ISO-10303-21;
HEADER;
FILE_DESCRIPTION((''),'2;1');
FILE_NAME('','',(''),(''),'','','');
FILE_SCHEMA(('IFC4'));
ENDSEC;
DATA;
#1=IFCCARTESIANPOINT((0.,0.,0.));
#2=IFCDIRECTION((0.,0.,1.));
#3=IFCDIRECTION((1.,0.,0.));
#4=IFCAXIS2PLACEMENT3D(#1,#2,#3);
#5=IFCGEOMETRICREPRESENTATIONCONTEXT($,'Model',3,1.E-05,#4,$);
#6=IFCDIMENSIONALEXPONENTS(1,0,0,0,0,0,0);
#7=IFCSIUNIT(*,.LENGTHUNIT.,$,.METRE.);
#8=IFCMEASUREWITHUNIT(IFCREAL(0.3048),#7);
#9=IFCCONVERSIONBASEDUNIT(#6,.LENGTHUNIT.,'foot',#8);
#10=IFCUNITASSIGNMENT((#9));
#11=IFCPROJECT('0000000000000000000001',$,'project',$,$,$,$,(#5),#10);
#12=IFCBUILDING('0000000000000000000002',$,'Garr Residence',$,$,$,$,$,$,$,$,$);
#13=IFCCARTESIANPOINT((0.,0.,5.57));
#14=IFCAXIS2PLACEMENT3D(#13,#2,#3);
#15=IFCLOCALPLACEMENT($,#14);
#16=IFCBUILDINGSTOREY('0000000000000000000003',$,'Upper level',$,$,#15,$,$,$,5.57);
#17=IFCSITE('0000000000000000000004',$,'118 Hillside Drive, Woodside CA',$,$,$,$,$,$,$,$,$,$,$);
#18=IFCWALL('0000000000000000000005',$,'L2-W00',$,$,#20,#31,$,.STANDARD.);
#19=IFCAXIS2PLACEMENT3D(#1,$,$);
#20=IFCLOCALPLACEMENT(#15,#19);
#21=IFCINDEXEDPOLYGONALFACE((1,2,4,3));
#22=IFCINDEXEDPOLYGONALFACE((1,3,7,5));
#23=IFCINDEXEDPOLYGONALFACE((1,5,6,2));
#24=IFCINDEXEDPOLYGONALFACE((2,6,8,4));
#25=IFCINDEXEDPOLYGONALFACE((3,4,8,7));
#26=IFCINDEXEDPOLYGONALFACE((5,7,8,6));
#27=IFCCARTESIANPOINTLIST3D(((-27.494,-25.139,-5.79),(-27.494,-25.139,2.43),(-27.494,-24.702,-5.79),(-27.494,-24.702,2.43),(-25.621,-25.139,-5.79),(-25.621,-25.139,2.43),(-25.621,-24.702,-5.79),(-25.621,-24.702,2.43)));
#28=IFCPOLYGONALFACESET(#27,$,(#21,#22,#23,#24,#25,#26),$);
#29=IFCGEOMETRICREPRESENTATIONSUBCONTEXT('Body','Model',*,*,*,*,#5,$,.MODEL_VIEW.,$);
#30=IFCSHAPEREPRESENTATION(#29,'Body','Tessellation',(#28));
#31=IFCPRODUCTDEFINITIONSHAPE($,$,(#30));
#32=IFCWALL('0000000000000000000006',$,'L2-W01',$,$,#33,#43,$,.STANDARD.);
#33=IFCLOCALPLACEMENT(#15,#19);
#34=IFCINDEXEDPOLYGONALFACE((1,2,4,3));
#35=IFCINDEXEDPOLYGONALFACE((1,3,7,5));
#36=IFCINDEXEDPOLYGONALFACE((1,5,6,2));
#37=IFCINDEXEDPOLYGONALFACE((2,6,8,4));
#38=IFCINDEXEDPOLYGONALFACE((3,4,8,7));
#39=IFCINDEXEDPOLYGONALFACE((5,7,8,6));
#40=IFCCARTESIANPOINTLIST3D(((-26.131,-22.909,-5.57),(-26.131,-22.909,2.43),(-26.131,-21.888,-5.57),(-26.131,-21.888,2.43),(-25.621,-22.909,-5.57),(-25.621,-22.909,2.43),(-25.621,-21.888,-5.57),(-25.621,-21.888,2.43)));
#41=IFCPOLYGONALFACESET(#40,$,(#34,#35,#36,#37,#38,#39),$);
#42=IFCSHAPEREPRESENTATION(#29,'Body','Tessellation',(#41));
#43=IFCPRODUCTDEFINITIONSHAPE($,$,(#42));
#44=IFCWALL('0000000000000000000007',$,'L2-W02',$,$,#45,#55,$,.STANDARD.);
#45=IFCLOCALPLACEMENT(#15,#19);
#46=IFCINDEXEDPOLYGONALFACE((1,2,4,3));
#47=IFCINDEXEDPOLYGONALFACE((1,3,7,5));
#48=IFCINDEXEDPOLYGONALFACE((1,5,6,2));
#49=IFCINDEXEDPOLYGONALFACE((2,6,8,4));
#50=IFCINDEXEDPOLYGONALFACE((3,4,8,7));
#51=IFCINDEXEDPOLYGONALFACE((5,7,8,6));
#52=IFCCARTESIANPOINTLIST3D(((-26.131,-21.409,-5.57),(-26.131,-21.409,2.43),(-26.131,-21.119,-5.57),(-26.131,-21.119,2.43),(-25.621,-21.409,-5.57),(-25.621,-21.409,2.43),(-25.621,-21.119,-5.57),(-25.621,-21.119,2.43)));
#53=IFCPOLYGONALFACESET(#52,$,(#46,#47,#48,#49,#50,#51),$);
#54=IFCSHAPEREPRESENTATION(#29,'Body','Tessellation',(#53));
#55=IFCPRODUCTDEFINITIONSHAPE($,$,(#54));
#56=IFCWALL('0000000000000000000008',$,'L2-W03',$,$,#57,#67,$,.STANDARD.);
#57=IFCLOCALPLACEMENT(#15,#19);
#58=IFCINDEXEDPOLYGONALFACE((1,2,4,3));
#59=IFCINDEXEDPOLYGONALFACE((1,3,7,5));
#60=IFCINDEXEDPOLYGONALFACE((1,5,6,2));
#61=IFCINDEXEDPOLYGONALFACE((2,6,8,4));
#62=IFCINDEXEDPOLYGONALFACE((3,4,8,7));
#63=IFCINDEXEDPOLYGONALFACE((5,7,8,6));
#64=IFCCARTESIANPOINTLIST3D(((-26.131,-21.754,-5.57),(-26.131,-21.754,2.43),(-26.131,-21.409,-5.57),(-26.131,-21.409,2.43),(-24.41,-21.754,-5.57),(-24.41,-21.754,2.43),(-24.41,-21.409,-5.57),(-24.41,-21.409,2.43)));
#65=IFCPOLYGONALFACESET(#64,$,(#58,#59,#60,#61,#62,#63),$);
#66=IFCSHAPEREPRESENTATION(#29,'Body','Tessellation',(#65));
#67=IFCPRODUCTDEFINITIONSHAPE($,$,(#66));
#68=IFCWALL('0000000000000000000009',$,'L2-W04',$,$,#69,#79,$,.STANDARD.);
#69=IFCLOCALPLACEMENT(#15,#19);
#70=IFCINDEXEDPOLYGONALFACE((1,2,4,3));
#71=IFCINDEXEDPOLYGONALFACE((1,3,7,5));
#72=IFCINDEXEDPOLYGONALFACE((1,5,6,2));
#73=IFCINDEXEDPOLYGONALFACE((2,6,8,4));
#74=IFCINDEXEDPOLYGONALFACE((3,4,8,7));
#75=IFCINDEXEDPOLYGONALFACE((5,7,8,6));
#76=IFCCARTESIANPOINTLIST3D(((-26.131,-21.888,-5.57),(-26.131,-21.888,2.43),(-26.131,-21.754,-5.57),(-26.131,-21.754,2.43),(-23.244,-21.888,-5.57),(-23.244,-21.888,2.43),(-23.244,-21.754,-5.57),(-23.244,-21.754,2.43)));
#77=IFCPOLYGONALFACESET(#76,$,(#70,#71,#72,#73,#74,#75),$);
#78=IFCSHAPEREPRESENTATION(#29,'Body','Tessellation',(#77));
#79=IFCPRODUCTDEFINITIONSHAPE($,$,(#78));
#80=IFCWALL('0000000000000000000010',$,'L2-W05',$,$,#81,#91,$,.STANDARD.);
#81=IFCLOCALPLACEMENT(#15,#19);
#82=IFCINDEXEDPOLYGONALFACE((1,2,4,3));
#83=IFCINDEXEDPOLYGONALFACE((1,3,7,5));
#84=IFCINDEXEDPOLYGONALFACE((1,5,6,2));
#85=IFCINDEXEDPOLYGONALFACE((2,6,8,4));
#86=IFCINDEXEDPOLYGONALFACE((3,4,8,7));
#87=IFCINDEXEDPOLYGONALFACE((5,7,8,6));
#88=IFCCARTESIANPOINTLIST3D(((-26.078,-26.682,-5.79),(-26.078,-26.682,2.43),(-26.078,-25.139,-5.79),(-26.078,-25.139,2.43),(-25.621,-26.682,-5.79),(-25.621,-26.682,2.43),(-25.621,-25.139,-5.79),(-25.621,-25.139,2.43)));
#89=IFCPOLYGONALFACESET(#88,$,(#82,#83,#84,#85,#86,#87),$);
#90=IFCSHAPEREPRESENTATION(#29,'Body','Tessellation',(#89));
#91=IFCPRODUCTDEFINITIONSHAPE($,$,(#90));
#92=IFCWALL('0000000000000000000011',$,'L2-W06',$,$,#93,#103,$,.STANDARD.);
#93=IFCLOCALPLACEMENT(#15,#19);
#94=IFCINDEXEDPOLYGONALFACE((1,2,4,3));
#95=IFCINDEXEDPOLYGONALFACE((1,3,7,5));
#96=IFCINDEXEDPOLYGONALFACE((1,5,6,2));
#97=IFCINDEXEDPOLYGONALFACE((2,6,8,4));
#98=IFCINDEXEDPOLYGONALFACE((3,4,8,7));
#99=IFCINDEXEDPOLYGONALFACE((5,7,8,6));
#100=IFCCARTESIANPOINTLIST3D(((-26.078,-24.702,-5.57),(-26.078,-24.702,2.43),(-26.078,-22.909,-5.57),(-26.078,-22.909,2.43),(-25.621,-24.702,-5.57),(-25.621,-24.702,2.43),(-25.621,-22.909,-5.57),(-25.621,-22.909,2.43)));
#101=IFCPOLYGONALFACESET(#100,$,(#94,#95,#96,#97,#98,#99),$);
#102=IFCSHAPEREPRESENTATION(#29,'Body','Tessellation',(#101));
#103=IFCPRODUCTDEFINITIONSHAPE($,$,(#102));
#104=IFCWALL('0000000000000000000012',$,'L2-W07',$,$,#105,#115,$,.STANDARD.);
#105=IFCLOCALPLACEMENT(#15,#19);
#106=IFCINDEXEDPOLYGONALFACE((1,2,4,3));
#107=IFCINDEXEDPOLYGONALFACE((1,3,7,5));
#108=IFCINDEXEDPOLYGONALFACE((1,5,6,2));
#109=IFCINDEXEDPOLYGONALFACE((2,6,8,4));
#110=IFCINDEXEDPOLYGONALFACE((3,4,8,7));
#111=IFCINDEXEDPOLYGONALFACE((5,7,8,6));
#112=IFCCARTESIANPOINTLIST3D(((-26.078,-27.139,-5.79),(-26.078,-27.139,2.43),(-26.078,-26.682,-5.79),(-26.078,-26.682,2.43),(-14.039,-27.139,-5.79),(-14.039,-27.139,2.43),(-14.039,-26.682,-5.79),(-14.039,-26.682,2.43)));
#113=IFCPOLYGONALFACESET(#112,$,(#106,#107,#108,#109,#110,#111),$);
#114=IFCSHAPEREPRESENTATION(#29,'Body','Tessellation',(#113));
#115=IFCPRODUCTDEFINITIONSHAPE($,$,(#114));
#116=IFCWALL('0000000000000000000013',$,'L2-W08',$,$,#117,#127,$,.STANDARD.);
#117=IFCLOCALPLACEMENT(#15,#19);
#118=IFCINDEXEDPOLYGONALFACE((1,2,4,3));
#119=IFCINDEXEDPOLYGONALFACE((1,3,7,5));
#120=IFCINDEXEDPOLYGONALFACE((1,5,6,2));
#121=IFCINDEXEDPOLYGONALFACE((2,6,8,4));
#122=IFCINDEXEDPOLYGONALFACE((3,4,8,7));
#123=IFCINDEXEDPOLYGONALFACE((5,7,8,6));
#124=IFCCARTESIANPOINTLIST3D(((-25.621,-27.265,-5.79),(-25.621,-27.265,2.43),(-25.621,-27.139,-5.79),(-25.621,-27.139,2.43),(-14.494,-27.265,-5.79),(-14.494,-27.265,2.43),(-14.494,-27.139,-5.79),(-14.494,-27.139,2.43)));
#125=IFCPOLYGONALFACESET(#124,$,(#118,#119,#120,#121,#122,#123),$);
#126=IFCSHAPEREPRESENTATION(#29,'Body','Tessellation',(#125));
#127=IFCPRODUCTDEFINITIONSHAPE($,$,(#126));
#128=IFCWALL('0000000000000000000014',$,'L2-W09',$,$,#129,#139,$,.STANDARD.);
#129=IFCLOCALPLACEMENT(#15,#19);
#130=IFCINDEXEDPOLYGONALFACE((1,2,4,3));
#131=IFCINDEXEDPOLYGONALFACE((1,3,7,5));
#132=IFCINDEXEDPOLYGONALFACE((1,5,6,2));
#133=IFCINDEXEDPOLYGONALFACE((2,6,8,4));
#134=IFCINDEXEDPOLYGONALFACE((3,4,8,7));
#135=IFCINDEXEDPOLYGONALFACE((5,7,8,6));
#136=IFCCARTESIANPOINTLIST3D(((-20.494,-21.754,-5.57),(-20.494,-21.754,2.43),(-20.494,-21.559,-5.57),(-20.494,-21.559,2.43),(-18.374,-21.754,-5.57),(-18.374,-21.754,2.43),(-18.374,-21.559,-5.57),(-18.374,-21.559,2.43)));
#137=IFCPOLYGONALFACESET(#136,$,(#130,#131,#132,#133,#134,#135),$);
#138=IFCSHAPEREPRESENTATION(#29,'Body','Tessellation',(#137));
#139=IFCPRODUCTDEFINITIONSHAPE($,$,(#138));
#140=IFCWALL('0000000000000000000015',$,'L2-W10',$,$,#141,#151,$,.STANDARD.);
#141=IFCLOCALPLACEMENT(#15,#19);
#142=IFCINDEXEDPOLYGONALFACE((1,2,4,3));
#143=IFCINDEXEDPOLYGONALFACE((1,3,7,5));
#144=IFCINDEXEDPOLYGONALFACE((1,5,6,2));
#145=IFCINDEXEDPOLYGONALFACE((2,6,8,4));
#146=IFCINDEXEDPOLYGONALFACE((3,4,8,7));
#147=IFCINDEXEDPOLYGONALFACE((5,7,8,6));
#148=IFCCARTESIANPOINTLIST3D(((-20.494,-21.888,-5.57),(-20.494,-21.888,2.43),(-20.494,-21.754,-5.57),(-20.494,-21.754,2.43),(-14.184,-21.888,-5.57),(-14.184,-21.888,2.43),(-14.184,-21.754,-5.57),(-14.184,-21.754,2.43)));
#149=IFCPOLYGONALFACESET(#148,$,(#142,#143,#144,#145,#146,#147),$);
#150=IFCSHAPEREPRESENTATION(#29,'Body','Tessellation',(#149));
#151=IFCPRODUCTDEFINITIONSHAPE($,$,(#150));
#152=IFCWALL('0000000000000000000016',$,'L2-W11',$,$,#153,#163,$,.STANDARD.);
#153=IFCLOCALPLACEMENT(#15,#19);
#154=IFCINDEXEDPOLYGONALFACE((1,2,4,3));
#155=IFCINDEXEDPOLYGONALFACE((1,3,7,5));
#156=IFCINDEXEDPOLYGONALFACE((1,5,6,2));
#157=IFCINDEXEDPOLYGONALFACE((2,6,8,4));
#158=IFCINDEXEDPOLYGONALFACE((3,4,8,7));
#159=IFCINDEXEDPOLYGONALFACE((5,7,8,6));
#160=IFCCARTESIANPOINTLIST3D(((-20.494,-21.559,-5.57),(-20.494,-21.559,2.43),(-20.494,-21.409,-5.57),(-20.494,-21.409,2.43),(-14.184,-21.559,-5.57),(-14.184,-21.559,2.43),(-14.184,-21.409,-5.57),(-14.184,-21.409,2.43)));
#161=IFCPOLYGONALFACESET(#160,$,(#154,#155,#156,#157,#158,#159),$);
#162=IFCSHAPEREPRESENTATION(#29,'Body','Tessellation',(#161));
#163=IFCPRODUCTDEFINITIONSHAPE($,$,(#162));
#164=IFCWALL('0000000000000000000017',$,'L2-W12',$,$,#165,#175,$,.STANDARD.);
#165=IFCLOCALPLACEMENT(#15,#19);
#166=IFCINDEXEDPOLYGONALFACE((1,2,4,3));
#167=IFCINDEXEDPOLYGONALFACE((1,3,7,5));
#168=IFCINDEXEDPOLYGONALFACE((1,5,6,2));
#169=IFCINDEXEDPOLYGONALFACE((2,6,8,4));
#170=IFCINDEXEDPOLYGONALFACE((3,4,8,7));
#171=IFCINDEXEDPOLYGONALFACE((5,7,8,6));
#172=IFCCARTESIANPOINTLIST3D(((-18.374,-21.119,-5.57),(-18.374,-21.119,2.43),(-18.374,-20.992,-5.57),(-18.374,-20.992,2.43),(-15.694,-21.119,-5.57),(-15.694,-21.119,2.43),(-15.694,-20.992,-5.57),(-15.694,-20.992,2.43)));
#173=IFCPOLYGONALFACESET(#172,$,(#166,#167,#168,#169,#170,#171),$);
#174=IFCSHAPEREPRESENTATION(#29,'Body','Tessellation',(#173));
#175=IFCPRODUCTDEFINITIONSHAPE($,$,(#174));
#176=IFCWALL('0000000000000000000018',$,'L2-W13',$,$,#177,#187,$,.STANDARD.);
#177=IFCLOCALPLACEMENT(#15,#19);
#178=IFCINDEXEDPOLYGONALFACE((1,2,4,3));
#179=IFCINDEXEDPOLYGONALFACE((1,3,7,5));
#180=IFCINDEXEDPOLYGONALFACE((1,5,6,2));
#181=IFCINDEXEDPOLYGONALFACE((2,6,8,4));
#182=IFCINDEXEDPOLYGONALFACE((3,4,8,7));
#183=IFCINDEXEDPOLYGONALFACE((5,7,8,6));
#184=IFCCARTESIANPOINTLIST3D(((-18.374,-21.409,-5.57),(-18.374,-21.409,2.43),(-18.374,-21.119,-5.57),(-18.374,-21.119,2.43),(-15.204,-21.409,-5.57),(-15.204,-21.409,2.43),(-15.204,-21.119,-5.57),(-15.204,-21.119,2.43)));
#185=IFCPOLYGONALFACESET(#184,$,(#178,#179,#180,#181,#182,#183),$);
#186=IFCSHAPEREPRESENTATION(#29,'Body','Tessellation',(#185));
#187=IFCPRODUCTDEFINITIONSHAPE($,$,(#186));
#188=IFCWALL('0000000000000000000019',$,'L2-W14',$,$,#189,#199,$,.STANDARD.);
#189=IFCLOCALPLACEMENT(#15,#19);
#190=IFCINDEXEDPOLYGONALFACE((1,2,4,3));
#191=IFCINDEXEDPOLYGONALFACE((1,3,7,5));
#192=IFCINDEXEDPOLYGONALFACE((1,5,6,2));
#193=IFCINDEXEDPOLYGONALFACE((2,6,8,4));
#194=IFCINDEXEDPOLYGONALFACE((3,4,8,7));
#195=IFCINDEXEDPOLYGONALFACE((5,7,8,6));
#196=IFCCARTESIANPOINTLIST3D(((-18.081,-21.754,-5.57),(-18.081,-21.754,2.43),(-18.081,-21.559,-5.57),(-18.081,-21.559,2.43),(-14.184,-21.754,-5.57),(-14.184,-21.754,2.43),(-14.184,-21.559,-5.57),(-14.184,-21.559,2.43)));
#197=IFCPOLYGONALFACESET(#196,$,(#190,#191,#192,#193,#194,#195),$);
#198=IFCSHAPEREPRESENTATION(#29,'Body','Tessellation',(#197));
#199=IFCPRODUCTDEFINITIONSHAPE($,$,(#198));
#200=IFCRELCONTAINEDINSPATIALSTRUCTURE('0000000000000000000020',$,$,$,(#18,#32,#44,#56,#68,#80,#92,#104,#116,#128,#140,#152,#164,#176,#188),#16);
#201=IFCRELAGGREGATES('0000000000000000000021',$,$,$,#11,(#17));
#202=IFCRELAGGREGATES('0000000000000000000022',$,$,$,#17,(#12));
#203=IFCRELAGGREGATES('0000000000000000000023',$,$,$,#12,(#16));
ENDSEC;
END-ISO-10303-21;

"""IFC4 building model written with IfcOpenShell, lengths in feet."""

from ifc_helpers import new_model, entity, si_unit, converted_unit, frame, origin, origin_with_axes, place, context, subcontext, project, spatial, polyline, outline, extrude, element, save


model = new_model("IFC4")

# Units and contexts
model_context = context("Model", 3, precision=1e-05, world=origin_with_axes())
body_context = subcontext(model_context, "Body", "Model", "MODEL_VIEW")
ifc_project = project(units=[converted_unit("LENGTHUNIT", "foot", entity("IfcReal", 0.3048), si_unit("LENGTHUNIT", "METRE"), dimensions=[1, 0, 0, 0, 0, 0, 0])], contexts=[model_context])

# Site, building, storey
site = spatial("IfcSite", under=ifc_project, Name="118 Hillside Drive, Woodside CA")
building = spatial("IfcBuilding", under=site, Name="Garr Residence")
storey_placement = place(None, frame((0.0, 0.0, 5.57), z_axis=(0.0, 0.0, 1.0), x_axis=(1.0, 0.0, 0.0)))
storey = spatial("IfcBuildingStorey", under=building, at=storey_placement, Name="Upper level", Elevation=5.57)

# Walls
wall_1_placement = place(storey_placement, frame((0.0, 0.0, -5.79), z_axis=(0.0, 0.0, 1.0), x_axis=(1.0, 0.0, 0.0)))
element("IfcWall", 1, at=wall_1_placement, inside=storey, Name="L2-W00", PredefinedType="STANDARD", context=body_context, shape_type="SweptSolid", body=[
    extrude(outline(polyline([(-25.621, -25.139), (-25.621, -24.702), (-27.494, -24.702), (-27.494, -25.139), (-25.621, -25.139)])), origin(), (0.0, 0.0, 1.0), 8.22),
])
wall_2_placement = place(storey_placement, frame((0.0, 0.0, -5.57), z_axis=(0.0, 0.0, 1.0), x_axis=(1.0, 0.0, 0.0)))
element("IfcWall", 2, at=wall_2_placement, inside=storey, Name="L2-W01", PredefinedType="STANDARD", context=body_context, shape_type="SweptSolid", body=[
    extrude(outline(polyline([(-25.621, -22.909), (-25.621, -21.888), (-26.131, -21.888), (-26.131, -22.909), (-25.621, -22.909)])), origin(), (0.0, 0.0, 1.0), 8.0),
])
wall_3_placement = place(storey_placement, frame((0.0, 0.0, -5.57), z_axis=(0.0, 0.0, 1.0), x_axis=(1.0, 0.0, 0.0)))
element("IfcWall", 3, at=wall_3_placement, inside=storey, Name="L2-W02", PredefinedType="STANDARD", context=body_context, shape_type="SweptSolid", body=[
    extrude(outline(polyline([(-25.621, -21.409), (-25.621, -21.119), (-26.131, -21.119), (-26.131, -21.409), (-25.621, -21.409)])), origin(), (0.0, 0.0, 1.0), 8.0),
])
wall_4_placement = place(storey_placement, frame((0.0, 0.0, -5.57), z_axis=(0.0, 0.0, 1.0), x_axis=(1.0, 0.0, 0.0)))
element("IfcWall", 4, at=wall_4_placement, inside=storey, Name="L2-W03", PredefinedType="STANDARD", context=body_context, shape_type="SweptSolid", body=[
    extrude(outline(polyline([(-24.41, -21.754), (-24.41, -21.409), (-26.131, -21.409), (-26.131, -21.754), (-24.41, -21.754)])), origin(), (0.0, 0.0, 1.0), 8.0),
])
wall_5_placement = place(storey_placement, frame((0.0, 0.0, -5.57), z_axis=(0.0, 0.0, 1.0), x_axis=(1.0, 0.0, 0.0)))
element("IfcWall", 5, at=wall_5_placement, inside=storey, Name="L2-W04", PredefinedType="STANDARD", context=body_context, shape_type="SweptSolid", body=[
    extrude(outline(polyline([(-23.244, -21.888), (-23.244, -21.754), (-26.131, -21.754), (-26.131, -21.888), (-23.244, -21.888)])), origin(), (0.0, 0.0, 1.0), 8.0),
])
wall_6_placement = place(storey_placement, frame((0.0, 0.0, -5.79), z_axis=(0.0, 0.0, 1.0), x_axis=(1.0, 0.0, 0.0)))
element("IfcWall", 6, at=wall_6_placement, inside=storey, Name="L2-W05", PredefinedType="STANDARD", context=body_context, shape_type="SweptSolid", body=[
    extrude(outline(polyline([(-25.621, -26.682), (-25.621, -25.139), (-26.078, -25.139), (-26.078, -26.682), (-25.621, -26.682)])), origin(), (0.0, 0.0, 1.0), 8.22),
])
wall_7_placement = place(storey_placement, frame((0.0, 0.0, -5.57), z_axis=(0.0, 0.0, 1.0), x_axis=(1.0, 0.0, 0.0)))
element("IfcWall", 7, at=wall_7_placement, inside=storey, Name="L2-W06", PredefinedType="STANDARD", context=body_context, shape_type="SweptSolid", body=[
    extrude(outline(polyline([(-25.621, -24.702), (-25.621, -22.909), (-26.078, -22.909), (-26.078, -24.702), (-25.621, -24.702)])), origin(), (0.0, 0.0, 1.0), 8.0),
])
wall_8_placement = place(storey_placement, frame((0.0, 0.0, -5.79), z_axis=(0.0, 0.0, 1.0), x_axis=(1.0, 0.0, 0.0)))
element("IfcWall", 8, at=wall_8_placement, inside=storey, Name="L2-W07", PredefinedType="STANDARD", context=body_context, shape_type="SweptSolid", body=[
    extrude(outline(polyline([(-14.039, -27.139), (-14.039, -26.682), (-26.078, -26.682), (-26.078, -27.139), (-14.039, -27.139)])), origin(), (0.0, 0.0, 1.0), 8.22),
])
wall_9_placement = place(storey_placement, frame((0.0, 0.0, -5.79), z_axis=(0.0, 0.0, 1.0), x_axis=(1.0, 0.0, 0.0)))
element("IfcWall", 9, at=wall_9_placement, inside=storey, Name="L2-W08", PredefinedType="STANDARD", context=body_context, shape_type="SweptSolid", body=[
    extrude(outline(polyline([(-14.494, -27.265), (-14.494, -27.139), (-25.621, -27.139), (-25.621, -27.265), (-14.494, -27.265)])), origin(), (0.0, 0.0, 1.0), 8.22),
])
wall_10_placement = place(storey_placement, frame((0.0, 0.0, -5.57), z_axis=(0.0, 0.0, 1.0), x_axis=(1.0, 0.0, 0.0)))
element("IfcWall", 10, at=wall_10_placement, inside=storey, Name="L2-W09", PredefinedType="STANDARD", context=body_context, shape_type="SweptSolid", body=[
    extrude(outline(polyline([(-18.374, -21.754), (-18.374, -21.559), (-20.494, -21.559), (-20.494, -21.754), (-18.374, -21.754)])), origin(), (0.0, 0.0, 1.0), 8.0),
])
wall_11_placement = place(storey_placement, frame((0.0, 0.0, -5.57), z_axis=(0.0, 0.0, 1.0), x_axis=(1.0, 0.0, 0.0)))
element("IfcWall", 11, at=wall_11_placement, inside=storey, Name="L2-W10", PredefinedType="STANDARD", context=body_context, shape_type="SweptSolid", body=[
    extrude(outline(polyline([(-14.184, -21.888), (-14.184, -21.754), (-20.494, -21.754), (-20.494, -21.888), (-14.184, -21.888)])), origin(), (0.0, 0.0, 1.0), 8.0),
])
wall_12_placement = place(storey_placement, frame((0.0, 0.0, -5.57), z_axis=(0.0, 0.0, 1.0), x_axis=(1.0, 0.0, 0.0)))
element("IfcWall", 12, at=wall_12_placement, inside=storey, Name="L2-W11", PredefinedType="STANDARD", context=body_context, shape_type="SweptSolid", body=[
    extrude(outline(polyline([(-14.184, -21.559), (-14.184, -21.409), (-20.494, -21.409), (-20.494, -21.559), (-14.184, -21.559)])), origin(), (0.0, 0.0, 1.0), 8.0),
])
wall_13_placement = place(storey_placement, frame((0.0, 0.0, -5.57), z_axis=(0.0, 0.0, 1.0), x_axis=(1.0, 0.0, 0.0)))
element("IfcWall", 13, at=wall_13_placement, inside=storey, Name="L2-W12", PredefinedType="STANDARD", context=body_context, shape_type="SweptSolid", body=[
    extrude(outline(polyline([(-15.694, -21.119), (-15.694, -20.992), (-18.374, -20.992), (-18.374, -21.119), (-15.694, -21.119)])), origin(), (0.0, 0.0, 1.0), 8.0),
])
wall_14_placement = place(storey_placement, frame((0.0, 0.0, -5.57), z_axis=(0.0, 0.0, 1.0), x_axis=(1.0, 0.0, 0.0)))
element("IfcWall", 14, at=wall_14_placement, inside=storey, Name="L2-W13", PredefinedType="STANDARD", context=body_context, shape_type="SweptSolid", body=[
    extrude(outline(polyline([(-15.204, -21.409), (-15.204, -21.119), (-18.374, -21.119), (-18.374, -21.409), (-15.204, -21.409)])), origin(), (0.0, 0.0, 1.0), 8.0),
])
wall_15_placement = place(storey_placement, frame((0.0, 0.0, -5.57), z_axis=(0.0, 0.0, 1.0), x_axis=(1.0, 0.0, 0.0)))
element("IfcWall", 15, at=wall_15_placement, inside=storey, Name="L2-W14", PredefinedType="STANDARD", context=body_context, shape_type="SweptSolid", body=[
    extrude(outline(polyline([(-14.184, -21.754), (-14.184, -21.559), (-18.081, -21.559), (-18.081, -21.754), (-14.184, -21.754)])), origin(), (0.0, 0.0, 1.0), 8.0),
])

save(model, "model.ifc")
